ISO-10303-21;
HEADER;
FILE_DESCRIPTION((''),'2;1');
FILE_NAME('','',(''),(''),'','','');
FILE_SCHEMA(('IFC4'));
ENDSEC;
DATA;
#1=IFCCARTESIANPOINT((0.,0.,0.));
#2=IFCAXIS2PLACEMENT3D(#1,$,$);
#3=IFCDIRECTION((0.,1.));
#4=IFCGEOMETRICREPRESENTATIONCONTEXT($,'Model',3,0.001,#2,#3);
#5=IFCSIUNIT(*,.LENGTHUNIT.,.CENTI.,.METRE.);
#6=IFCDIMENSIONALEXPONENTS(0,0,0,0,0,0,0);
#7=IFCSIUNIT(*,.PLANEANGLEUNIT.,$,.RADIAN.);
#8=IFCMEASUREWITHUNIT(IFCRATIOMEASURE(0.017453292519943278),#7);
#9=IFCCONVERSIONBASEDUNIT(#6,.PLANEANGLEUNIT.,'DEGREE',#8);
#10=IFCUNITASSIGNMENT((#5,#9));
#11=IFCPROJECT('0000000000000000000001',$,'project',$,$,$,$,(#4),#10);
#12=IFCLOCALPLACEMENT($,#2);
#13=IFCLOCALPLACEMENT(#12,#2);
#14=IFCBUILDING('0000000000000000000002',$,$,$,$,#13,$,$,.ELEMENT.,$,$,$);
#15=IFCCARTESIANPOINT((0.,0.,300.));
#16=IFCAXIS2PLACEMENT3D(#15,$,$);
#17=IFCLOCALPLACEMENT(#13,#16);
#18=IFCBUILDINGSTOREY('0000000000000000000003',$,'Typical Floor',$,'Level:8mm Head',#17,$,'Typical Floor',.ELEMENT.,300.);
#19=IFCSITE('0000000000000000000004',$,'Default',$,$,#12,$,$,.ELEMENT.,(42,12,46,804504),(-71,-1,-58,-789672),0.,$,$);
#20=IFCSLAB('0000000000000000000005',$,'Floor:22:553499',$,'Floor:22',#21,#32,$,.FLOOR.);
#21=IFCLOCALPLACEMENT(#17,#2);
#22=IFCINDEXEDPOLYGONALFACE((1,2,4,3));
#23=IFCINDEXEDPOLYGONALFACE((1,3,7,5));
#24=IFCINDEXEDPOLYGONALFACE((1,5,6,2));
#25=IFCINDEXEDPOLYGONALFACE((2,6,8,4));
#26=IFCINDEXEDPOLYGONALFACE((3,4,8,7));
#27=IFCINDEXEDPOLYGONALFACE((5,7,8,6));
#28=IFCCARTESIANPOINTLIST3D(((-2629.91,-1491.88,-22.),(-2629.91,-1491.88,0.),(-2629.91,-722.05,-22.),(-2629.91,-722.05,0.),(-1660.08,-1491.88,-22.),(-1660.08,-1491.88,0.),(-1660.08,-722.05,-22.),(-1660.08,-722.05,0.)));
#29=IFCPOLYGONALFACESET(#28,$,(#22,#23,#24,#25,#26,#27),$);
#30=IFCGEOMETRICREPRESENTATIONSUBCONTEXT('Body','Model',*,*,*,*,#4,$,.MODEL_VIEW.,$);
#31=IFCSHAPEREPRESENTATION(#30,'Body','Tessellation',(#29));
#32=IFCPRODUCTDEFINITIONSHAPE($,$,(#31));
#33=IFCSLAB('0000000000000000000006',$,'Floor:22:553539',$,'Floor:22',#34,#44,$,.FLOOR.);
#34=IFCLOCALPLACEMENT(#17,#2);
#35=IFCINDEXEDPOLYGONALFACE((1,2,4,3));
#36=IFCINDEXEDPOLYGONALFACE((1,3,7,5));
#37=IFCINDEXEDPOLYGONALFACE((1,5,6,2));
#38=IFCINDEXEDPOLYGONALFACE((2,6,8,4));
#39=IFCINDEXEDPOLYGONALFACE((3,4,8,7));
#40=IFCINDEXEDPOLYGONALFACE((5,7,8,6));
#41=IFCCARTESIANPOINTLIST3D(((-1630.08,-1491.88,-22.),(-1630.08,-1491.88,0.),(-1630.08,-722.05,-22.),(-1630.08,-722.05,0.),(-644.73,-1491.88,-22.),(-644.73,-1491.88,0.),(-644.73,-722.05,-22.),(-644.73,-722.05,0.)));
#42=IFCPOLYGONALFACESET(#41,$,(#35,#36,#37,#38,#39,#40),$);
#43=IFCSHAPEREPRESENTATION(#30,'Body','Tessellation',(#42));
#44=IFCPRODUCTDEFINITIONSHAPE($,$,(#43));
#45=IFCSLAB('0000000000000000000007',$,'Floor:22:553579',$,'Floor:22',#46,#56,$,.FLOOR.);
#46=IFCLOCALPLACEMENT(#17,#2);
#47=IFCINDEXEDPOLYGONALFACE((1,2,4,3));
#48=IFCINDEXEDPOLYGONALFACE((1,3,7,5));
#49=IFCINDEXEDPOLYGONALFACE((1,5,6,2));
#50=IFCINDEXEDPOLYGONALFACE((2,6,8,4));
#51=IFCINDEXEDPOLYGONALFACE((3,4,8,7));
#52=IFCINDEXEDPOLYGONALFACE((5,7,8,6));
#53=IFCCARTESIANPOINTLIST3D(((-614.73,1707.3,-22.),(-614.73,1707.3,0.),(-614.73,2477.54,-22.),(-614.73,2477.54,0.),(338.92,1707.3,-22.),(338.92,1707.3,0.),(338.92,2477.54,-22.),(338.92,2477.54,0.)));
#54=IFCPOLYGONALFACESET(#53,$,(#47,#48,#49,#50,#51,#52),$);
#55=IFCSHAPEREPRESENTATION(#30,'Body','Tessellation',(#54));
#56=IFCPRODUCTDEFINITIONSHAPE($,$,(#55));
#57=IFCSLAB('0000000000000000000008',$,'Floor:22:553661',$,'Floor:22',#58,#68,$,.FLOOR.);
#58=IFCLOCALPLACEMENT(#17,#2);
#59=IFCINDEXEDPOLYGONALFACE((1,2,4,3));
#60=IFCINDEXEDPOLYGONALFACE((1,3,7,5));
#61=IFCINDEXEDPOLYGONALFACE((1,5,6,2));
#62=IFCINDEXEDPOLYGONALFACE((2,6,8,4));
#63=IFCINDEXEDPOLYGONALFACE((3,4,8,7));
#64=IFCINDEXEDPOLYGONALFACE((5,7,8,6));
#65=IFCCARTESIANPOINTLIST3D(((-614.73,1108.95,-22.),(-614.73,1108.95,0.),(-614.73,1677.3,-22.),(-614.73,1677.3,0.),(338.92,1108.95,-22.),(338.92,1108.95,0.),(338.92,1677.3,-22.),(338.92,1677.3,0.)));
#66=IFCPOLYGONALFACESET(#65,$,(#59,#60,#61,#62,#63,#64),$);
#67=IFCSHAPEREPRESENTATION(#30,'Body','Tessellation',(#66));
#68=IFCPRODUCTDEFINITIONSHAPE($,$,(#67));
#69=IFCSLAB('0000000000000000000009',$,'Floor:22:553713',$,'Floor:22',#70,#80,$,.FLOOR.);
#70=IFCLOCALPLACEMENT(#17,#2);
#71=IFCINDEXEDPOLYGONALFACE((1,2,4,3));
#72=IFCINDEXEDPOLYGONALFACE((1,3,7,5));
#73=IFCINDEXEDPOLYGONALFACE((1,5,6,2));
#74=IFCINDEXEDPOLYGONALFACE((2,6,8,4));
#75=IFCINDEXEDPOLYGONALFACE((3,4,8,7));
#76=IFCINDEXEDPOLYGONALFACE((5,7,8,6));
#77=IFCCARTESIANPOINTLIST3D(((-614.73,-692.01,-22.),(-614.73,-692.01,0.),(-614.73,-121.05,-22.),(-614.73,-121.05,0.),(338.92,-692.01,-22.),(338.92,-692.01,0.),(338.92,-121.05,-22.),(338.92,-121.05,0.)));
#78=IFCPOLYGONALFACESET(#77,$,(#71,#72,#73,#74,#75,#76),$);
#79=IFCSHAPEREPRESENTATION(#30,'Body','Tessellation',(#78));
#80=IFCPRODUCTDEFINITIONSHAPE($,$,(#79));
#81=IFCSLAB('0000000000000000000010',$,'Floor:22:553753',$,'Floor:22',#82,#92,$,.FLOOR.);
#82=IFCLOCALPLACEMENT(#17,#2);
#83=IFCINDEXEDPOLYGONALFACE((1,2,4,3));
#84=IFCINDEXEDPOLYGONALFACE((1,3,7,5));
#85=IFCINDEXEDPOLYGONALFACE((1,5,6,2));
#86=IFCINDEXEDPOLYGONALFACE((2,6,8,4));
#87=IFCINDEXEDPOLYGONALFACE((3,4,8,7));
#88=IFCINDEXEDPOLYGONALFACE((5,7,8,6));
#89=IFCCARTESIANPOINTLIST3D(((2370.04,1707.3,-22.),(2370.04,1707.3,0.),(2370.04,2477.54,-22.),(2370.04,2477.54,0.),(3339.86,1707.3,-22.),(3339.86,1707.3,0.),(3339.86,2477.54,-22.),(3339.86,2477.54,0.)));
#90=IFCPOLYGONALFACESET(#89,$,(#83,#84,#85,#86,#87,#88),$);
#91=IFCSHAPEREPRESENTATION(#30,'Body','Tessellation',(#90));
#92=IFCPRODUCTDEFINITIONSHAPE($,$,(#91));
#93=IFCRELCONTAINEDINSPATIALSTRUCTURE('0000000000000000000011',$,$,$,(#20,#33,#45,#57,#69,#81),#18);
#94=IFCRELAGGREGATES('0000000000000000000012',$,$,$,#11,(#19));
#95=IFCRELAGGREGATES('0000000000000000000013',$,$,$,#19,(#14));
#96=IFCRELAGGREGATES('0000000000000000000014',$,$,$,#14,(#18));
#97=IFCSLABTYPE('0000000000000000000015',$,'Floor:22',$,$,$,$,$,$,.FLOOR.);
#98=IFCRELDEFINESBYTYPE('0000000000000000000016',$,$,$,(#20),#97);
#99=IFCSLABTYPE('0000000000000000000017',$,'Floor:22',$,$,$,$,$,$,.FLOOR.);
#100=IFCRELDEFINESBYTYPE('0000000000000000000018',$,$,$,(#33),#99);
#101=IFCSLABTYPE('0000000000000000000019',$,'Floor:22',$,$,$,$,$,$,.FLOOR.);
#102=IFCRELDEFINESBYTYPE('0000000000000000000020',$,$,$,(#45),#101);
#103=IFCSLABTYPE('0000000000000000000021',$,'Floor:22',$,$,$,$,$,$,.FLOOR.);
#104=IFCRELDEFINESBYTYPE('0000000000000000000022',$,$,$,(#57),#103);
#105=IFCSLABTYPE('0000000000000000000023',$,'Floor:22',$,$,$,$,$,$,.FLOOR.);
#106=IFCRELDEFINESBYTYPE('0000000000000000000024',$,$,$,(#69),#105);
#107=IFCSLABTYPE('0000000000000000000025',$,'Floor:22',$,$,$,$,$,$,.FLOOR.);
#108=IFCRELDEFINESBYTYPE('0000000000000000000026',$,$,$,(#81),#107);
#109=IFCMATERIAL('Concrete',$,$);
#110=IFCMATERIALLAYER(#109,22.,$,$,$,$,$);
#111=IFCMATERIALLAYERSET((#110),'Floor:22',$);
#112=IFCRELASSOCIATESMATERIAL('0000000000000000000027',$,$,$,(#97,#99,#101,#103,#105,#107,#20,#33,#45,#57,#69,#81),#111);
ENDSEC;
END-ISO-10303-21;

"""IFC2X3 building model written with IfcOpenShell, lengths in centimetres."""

from ifc_helpers import new_model, entity, si_unit, converted_unit, direction, frame, frame_2d, origin, origin_2d_with_axis, place, context, subcontext, project, spatial, rectangle, extrude, material, layer, layer_set, layer_usage, type_object, element, save


model = new_model("IFC2X3")

# Units and contexts
model_context = context("Model", 3, precision=0.001, world=origin(), true_north=direction((0.0, 1.0)))
body_context = subcontext(model_context, "Body", "Model", "MODEL_VIEW")
ifc_project = project(units=[si_unit("LENGTHUNIT", "METRE", prefix="CENTI"), converted_unit("PLANEANGLEUNIT", "DEGREE", entity("IfcRatioMeasure", 0.017453292519943278), si_unit("PLANEANGLEUNIT", "RADIAN"), dimensions=[0, 0, 0, 0, 0, 0, 0])], contexts=[model_context])

# Site, building, storey
site_placement = place(None, origin())
site = spatial("IfcSite", under=ifc_project, at=site_placement, Name="Default", CompositionType="ELEMENT", RefLatitude=(42, 12, 46, 804504), RefLongitude=(-71, -1, -58, -789672), RefElevation=0.0)
building_placement = place(site_placement, origin())
building = spatial("IfcBuilding", under=site, at=building_placement, CompositionType="ELEMENT")
storey_placement = place(building_placement, frame((0.0, 0.0, 300.0)))
storey = spatial("IfcBuildingStorey", under=building, at=storey_placement, Name="Typical Floor", ObjectType="Level:8mm Head", LongName="Typical Floor", CompositionType="ELEMENT", Elevation=300.0)

# Shared definitions
ifc_material = material(Name="Concrete")

# Slabs
ifc_layer = layer(ifc_material, 22.0)
ifc_layer_set = layer_set([ifc_layer], Name="Floor:22")
ifc_layer_usage_1 = layer_usage(ifc_layer_set, "AXIS3", "POSITIVE", 0.0)
slab_type_1 = type_object("IfcSlabType", Name="Floor:22", PredefinedType="FLOOR", material=ifc_layer_set)
slab_1_placement = place(storey_placement, origin())
element("IfcSlab", 1, at=slab_1_placement, inside=storey, type_object=slab_type_1, material=ifc_layer_usage_1, Name="Floor:22:553499", ObjectType="Floor:22", PredefinedType="FLOOR", context=body_context, shape_type="SweptSolid", body=[
    extrude(rectangle(XDim=769.83, YDim=969.83, at=frame_2d((0.0, 0.0), x_axis=(1.0, 0.0))), frame((-2144.99, -1106.96, 0.0), z_axis=(0.0, 0.0, -1.0), x_axis=(0.0, 1.0, 0.0)), (0.0, 0.0, 1.0), 22.0),
])
ifc_layer_usage_2 = layer_usage(ifc_layer_set, "AXIS3", "POSITIVE", 0.0)
slab_type_2 = type_object("IfcSlabType", Name="Floor:22", PredefinedType="FLOOR", material=ifc_layer_set)
slab_2_placement = place(storey_placement, origin())
element("IfcSlab", 2, at=slab_2_placement, inside=storey, type_object=slab_type_2, material=ifc_layer_usage_2, Name="Floor:22:553539", ObjectType="Floor:22", PredefinedType="FLOOR", context=body_context, shape_type="SweptSolid", body=[
    extrude(rectangle(XDim=769.83, YDim=985.35, at=frame_2d((0.0, 0.0), x_axis=(1.0, 0.0))), frame((-1137.41, -1106.96, 0.0), z_axis=(0.0, 0.0, -1.0), x_axis=(0.0, 1.0, 0.0)), (0.0, 0.0, 1.0), 22.0),
])
ifc_layer_usage_3 = layer_usage(ifc_layer_set, "AXIS3", "POSITIVE", 0.0)
slab_type_3 = type_object("IfcSlabType", Name="Floor:22", PredefinedType="FLOOR", material=ifc_layer_set)
slab_3_placement = place(storey_placement, origin())
element("IfcSlab", 3, at=slab_3_placement, inside=storey, type_object=slab_type_3, material=ifc_layer_usage_3, Name="Floor:22:553579", ObjectType="Floor:22", PredefinedType="FLOOR", context=body_context, shape_type="SweptSolid", body=[
    extrude(rectangle(XDim=770.24, YDim=953.65, at=frame_2d((0.0, 0.0), x_axis=(1.0, 0.0))), frame((-137.91, 2092.42, 0.0), z_axis=(0.0, 0.0, -1.0), x_axis=(0.0, 1.0, 0.0)), (0.0, 0.0, 1.0), 22.0),
])
ifc_layer_usage_4 = layer_usage(ifc_layer_set, "AXIS3", "POSITIVE", 0.0)
slab_type_4 = type_object("IfcSlabType", Name="Floor:22", PredefinedType="FLOOR", material=ifc_layer_set)
slab_4_placement = place(storey_placement, origin())
element("IfcSlab", 4, at=slab_4_placement, inside=storey, type_object=slab_type_4, material=ifc_layer_usage_4, Name="Floor:22:553661", ObjectType="Floor:22", PredefinedType="FLOOR", context=body_context, shape_type="SweptSolid", body=[
    extrude(rectangle(XDim=568.35, YDim=953.65, at=origin_2d_with_axis()), frame((-137.91, 1393.13, 0.0), z_axis=(0.0, 0.0, -1.0), x_axis=(0.0, 1.0, 0.0)), (0.0, 0.0, 1.0), 22.0),
])
ifc_layer_usage_5 = layer_usage(ifc_layer_set, "AXIS3", "POSITIVE", 0.0)
slab_type_5 = type_object("IfcSlabType", Name="Floor:22", PredefinedType="FLOOR", material=ifc_layer_set)
slab_5_placement = place(storey_placement, origin())
element("IfcSlab", 5, at=slab_5_placement, inside=storey, type_object=slab_type_5, material=ifc_layer_usage_5, Name="Floor:22:553713", ObjectType="Floor:22", PredefinedType="FLOOR", context=body_context, shape_type="SweptSolid", body=[
    extrude(rectangle(XDim=570.97, YDim=953.65, at=origin_2d_with_axis()), frame((-137.91, -406.53, 0.0), z_axis=(0.0, 0.0, -1.0), x_axis=(0.0, 1.0, 0.0)), (0.0, 0.0, 1.0), 22.0),
])
ifc_layer_usage_6 = layer_usage(ifc_layer_set, "AXIS3", "POSITIVE", 0.0)
slab_type_6 = type_object("IfcSlabType", Name="Floor:22", PredefinedType="FLOOR", material=ifc_layer_set)
slab_6_placement = place(storey_placement, origin())
element("IfcSlab", 6, at=slab_6_placement, inside=storey, type_object=slab_type_6, material=ifc_layer_usage_6, Name="Floor:22:553753", ObjectType="Floor:22", PredefinedType="FLOOR", context=body_context, shape_type="SweptSolid", body=[
    extrude(rectangle(XDim=770.24, YDim=969.83, at=frame_2d((0.0, 0.0), x_axis=(1.0, 0.0))), frame((2854.95, 2092.42, 0.0), z_axis=(0.0, 0.0, -1.0), x_axis=(0.0, 1.0, 0.0)), (0.0, 0.0, 1.0), 22.0),
])

save(model, "model.ifc")
